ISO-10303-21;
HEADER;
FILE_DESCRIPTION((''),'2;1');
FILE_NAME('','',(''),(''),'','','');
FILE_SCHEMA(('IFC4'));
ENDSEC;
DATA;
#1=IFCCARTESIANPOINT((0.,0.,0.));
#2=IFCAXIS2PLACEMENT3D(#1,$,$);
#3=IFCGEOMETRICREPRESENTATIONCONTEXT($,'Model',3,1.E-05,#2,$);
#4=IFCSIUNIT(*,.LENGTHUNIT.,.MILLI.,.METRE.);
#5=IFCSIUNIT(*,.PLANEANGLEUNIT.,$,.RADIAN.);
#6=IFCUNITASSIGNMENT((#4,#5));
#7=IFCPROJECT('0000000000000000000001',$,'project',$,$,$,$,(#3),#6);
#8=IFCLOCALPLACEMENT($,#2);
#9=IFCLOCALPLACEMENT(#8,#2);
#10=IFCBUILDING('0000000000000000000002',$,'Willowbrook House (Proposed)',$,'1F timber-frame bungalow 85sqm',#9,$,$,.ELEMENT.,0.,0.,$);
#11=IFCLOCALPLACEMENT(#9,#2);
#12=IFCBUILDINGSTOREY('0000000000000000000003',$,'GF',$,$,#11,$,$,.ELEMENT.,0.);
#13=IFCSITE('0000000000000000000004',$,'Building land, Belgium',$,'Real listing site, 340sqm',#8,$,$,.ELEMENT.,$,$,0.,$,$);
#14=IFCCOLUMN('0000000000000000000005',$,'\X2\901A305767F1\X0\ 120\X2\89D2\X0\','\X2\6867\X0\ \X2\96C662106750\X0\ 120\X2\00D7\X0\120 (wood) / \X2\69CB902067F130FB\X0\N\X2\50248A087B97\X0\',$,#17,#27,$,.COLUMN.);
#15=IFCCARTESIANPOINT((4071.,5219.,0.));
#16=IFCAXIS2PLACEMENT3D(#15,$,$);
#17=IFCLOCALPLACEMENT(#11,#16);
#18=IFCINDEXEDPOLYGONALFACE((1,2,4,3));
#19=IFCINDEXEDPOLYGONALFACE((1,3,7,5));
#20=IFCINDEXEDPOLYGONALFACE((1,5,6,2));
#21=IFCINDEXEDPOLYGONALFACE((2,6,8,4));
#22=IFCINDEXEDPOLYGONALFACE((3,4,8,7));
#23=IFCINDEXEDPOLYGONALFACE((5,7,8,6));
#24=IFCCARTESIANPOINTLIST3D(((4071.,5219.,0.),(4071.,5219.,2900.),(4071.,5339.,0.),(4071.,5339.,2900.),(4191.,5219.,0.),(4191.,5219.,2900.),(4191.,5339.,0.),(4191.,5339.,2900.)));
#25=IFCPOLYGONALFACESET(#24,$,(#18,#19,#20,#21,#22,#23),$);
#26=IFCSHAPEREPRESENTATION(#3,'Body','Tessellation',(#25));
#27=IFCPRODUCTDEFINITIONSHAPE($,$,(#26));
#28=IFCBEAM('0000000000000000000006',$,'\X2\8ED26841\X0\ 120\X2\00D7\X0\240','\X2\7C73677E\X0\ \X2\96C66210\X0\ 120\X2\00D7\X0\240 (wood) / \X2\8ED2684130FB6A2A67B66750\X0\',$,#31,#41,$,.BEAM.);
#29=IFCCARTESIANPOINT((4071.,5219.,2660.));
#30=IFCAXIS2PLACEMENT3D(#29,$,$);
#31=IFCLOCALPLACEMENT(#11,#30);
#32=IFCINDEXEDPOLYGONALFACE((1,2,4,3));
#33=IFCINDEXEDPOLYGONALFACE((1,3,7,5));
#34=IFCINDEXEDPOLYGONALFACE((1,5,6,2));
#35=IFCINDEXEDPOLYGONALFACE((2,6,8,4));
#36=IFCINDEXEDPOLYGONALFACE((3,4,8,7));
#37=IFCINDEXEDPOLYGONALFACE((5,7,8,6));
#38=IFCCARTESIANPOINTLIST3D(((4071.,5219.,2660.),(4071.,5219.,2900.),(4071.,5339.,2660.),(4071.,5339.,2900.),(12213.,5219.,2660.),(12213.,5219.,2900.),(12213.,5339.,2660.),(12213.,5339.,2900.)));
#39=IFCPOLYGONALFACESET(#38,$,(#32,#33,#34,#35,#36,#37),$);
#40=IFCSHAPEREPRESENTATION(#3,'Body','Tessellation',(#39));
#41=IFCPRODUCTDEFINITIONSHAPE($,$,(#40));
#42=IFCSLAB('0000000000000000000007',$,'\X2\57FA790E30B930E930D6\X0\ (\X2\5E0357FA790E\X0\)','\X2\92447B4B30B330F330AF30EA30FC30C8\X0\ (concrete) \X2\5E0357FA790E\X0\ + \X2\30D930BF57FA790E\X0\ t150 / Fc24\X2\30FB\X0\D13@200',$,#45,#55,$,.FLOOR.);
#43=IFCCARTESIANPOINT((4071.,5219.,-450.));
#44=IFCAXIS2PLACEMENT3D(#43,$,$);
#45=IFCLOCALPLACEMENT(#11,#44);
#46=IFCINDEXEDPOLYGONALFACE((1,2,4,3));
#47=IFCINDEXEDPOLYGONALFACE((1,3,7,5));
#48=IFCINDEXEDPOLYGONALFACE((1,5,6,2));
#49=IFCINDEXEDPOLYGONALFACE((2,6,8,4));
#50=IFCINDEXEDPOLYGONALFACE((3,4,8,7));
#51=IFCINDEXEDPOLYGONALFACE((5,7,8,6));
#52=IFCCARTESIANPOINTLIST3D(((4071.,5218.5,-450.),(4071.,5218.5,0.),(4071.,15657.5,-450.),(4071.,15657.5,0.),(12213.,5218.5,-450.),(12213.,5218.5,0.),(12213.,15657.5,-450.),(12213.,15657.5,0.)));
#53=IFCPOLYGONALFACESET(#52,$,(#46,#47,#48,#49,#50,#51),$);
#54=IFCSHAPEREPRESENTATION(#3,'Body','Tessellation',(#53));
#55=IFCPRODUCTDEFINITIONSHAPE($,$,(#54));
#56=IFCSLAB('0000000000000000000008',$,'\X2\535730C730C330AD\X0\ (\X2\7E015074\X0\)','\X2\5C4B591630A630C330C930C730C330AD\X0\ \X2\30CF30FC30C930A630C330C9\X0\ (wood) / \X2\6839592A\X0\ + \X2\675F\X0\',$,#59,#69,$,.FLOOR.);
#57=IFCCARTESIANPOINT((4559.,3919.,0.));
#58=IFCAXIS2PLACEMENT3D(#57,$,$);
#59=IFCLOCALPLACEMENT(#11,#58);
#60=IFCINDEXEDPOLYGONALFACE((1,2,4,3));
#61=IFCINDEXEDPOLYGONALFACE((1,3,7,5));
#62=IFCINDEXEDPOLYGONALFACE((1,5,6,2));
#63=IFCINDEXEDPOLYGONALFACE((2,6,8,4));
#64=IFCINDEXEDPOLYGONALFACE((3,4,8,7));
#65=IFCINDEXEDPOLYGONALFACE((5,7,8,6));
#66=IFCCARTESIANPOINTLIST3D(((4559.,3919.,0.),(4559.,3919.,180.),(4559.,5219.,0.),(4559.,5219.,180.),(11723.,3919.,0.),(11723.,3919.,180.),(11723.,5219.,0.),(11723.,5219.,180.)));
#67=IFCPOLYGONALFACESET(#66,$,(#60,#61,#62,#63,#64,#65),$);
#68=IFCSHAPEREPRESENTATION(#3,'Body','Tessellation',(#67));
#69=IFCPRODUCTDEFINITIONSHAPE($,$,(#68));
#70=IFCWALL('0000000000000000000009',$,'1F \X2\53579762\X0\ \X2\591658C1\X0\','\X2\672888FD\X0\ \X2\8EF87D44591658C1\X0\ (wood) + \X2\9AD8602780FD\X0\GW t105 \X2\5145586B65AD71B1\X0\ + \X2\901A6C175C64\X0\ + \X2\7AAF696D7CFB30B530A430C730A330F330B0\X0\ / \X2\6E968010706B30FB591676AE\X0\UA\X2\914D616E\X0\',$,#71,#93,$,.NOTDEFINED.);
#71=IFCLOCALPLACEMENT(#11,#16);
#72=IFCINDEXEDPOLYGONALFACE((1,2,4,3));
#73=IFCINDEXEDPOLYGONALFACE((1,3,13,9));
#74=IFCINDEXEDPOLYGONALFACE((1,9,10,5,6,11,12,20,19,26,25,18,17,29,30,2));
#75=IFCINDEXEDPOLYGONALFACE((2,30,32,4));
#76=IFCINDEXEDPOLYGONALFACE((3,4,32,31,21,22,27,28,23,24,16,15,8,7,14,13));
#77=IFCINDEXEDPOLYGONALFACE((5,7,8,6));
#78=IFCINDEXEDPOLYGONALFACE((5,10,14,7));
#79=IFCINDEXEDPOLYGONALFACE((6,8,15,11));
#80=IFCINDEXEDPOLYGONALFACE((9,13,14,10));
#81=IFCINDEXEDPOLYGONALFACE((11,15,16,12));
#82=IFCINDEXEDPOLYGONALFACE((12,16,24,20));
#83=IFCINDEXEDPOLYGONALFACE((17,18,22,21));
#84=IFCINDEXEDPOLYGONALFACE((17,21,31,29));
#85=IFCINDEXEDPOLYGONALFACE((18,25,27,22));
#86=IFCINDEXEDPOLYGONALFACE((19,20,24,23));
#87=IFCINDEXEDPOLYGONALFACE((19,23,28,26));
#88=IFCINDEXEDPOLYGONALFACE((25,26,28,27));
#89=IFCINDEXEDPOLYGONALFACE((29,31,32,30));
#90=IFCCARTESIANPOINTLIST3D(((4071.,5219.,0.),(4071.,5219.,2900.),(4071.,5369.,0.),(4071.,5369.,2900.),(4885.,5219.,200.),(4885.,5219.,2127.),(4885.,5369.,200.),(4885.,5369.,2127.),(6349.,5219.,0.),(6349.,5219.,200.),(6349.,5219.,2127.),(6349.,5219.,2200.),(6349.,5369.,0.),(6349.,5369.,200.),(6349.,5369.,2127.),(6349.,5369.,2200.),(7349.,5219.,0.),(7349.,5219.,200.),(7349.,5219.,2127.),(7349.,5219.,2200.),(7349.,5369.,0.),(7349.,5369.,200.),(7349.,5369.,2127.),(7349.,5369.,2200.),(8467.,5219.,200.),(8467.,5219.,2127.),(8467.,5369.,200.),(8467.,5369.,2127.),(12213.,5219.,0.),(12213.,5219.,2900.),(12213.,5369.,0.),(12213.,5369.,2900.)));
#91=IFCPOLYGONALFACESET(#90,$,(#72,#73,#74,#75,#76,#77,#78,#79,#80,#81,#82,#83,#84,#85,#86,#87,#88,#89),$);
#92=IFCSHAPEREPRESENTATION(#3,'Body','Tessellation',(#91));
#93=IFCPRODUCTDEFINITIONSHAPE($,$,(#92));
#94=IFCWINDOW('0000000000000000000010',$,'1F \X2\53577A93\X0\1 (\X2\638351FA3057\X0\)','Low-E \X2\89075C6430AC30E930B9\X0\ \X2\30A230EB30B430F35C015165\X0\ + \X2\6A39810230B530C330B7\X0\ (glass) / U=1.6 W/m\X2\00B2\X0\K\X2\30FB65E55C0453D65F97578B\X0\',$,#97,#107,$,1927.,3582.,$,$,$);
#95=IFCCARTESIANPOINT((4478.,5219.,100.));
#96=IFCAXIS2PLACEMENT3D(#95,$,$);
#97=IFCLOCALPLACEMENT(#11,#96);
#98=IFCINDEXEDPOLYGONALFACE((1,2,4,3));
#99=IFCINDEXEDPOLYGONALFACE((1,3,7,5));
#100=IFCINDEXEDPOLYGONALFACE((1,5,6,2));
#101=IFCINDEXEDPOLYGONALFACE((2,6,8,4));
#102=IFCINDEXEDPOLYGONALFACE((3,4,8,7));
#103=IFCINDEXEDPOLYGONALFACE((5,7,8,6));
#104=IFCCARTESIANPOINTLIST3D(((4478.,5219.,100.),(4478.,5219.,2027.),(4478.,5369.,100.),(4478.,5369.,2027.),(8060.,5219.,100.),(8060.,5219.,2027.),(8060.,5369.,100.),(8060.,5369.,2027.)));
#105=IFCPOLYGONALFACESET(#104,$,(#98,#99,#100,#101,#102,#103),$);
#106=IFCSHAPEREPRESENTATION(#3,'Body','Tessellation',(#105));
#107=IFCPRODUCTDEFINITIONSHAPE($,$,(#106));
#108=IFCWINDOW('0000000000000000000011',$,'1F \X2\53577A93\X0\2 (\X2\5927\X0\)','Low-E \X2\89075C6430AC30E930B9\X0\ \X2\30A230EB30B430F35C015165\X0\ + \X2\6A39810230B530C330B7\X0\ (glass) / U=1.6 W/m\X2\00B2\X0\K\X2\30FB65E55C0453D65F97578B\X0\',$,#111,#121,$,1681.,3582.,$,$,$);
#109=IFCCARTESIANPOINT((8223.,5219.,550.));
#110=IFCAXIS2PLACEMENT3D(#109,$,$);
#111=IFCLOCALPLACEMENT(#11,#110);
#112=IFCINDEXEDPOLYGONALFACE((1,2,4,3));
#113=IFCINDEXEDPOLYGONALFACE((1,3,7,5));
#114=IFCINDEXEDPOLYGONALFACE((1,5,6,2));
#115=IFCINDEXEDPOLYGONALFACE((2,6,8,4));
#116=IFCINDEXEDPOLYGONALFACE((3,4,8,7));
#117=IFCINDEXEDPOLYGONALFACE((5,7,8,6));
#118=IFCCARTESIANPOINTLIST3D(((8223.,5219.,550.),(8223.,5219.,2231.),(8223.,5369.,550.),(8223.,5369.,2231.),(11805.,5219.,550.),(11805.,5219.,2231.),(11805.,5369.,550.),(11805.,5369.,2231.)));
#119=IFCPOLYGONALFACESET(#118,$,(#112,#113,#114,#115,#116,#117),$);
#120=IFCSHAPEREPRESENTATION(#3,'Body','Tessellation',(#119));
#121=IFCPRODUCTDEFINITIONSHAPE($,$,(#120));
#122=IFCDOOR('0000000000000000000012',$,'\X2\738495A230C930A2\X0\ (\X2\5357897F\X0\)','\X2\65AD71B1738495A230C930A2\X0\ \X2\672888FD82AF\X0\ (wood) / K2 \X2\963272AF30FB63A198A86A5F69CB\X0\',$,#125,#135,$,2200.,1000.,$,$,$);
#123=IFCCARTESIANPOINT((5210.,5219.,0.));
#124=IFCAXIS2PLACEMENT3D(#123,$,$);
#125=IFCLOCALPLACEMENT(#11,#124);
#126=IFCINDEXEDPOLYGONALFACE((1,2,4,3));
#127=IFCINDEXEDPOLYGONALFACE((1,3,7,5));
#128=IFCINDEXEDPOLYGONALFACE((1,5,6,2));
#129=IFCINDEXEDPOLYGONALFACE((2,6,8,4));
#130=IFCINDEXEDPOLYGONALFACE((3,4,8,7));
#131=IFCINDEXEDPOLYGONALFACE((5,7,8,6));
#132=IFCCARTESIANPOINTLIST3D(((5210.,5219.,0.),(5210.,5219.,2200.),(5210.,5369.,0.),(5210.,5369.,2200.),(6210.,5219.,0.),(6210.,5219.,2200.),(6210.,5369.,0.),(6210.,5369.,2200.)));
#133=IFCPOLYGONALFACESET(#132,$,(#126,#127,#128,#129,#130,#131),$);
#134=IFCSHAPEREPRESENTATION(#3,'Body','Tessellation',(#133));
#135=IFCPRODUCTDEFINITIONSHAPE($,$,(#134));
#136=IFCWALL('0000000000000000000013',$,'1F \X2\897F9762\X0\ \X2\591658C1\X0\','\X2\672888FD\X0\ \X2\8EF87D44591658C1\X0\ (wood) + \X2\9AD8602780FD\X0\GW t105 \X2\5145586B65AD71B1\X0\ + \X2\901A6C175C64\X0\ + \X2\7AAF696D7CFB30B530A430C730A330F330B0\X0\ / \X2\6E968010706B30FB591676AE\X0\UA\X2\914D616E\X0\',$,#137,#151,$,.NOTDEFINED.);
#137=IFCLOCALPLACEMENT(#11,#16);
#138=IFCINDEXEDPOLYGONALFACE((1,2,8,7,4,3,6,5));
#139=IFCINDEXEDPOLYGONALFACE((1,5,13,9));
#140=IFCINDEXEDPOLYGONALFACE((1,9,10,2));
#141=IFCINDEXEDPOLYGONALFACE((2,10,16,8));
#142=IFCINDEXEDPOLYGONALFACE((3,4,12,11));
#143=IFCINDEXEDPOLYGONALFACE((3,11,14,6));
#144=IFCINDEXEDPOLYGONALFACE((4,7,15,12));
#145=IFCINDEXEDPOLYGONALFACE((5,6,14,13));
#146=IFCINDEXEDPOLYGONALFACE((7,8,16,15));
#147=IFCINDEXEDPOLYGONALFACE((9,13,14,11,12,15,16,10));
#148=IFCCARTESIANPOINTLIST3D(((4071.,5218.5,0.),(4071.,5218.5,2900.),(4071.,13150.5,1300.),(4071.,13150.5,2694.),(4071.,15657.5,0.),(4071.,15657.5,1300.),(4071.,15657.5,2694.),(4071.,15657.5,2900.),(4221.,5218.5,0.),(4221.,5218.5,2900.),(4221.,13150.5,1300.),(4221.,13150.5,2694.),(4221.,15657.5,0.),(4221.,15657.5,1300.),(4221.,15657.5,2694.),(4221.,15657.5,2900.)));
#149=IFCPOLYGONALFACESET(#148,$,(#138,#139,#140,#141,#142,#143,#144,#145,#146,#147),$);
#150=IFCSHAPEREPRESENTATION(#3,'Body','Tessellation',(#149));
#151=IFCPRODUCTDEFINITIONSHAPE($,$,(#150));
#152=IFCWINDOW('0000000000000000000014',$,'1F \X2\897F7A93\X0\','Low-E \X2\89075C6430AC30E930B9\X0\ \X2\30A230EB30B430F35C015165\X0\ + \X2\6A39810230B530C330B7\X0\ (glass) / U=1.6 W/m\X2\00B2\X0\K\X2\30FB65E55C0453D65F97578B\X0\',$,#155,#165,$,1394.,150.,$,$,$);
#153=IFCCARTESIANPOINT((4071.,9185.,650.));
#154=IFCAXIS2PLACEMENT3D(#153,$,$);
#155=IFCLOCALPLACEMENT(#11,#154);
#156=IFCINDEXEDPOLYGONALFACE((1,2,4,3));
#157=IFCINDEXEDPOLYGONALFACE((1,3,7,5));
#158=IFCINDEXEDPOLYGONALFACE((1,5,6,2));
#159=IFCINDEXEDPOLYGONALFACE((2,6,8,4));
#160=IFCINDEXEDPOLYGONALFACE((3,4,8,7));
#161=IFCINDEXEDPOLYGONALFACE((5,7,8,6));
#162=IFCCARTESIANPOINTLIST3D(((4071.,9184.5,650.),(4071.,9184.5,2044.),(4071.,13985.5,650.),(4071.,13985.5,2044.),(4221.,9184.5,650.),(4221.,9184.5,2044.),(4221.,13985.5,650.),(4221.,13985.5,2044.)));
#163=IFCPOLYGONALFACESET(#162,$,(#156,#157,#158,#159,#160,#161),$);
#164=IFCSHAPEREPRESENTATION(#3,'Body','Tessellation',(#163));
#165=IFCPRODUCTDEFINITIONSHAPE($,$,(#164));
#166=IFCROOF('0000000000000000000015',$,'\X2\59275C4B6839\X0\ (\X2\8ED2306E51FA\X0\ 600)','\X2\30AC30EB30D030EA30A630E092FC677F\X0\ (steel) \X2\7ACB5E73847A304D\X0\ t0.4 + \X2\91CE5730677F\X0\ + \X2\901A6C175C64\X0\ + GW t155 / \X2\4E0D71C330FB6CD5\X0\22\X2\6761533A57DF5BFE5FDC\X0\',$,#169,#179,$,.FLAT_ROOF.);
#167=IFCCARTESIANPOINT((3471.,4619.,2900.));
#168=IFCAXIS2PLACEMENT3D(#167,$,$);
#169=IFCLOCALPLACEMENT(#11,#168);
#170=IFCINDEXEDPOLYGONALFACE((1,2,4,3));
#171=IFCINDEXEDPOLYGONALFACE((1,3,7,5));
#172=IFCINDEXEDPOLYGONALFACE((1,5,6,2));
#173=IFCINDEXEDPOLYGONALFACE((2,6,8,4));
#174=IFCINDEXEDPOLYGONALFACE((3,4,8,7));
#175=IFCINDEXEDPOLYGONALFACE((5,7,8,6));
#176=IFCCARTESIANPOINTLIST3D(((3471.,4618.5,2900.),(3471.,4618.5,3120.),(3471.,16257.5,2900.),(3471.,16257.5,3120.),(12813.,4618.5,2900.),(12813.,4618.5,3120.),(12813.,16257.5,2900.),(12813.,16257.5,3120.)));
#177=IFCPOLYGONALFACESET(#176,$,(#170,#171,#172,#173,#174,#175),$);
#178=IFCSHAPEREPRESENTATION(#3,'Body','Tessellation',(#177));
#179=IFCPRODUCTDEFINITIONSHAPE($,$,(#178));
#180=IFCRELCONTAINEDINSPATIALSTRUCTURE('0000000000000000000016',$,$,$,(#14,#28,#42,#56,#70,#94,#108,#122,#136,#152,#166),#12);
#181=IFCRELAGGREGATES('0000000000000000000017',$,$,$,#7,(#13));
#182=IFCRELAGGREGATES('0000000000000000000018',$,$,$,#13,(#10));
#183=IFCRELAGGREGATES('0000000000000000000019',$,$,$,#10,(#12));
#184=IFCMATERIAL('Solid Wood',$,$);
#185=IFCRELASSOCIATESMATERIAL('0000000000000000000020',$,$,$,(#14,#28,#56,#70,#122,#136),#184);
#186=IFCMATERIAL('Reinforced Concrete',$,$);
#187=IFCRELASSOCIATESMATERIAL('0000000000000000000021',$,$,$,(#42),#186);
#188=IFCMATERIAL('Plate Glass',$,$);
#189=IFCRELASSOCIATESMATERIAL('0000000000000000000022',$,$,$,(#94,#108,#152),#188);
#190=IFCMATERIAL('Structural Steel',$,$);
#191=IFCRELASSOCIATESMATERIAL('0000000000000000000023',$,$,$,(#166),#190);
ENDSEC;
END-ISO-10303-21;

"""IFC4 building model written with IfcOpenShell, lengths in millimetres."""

from ifc_helpers import new_model, si_unit, frame, frame_2d, origin, place, context, project, spatial, rectangle, extrude, material, element, fill, save


model = new_model("IFC4")

# Units and contexts
model_context = context("Model", 3, precision=1e-05, world=origin())
ifc_project = project(units=[si_unit("LENGTHUNIT", "METRE", prefix="MILLI"), si_unit("PLANEANGLEUNIT", "RADIAN")], contexts=[model_context])

# Site, building, storey
site_placement = place(None, origin())
site = spatial("IfcSite", under=ifc_project, at=site_placement, Name="Building land, Belgium", ObjectType="Real listing site, 340sqm", CompositionType="ELEMENT", RefElevation=0.0)
building_placement = place(site_placement, origin())
building = spatial("IfcBuilding", under=site, at=building_placement, Name="Willowbrook House (Proposed)", ObjectType="1F timber-frame bungalow 85sqm", CompositionType="ELEMENT", ElevationOfRefHeight=0.0, ElevationOfTerrain=0.0)
storey_placement = place(building_placement, origin())
storey = spatial("IfcBuildingStorey", under=building, at=storey_placement, Name="GF", CompositionType="ELEMENT", Elevation=0.0)

# Column
ifc_material_1 = material(Name="Solid Wood")
column_1_placement = place(storey_placement, frame((4071.0, 5219.0, 0.0)))
element("IfcColumn", 1, at=column_1_placement, inside=storey, material=ifc_material_1, Name="通し柱 120角", Description="桧 集成材 120×120 (wood) / 構造柱・N値計算", PredefinedType="COLUMN", context=model_context, shape_type="SweptSolid", body=[
    extrude(rectangle(XDim=120.0, YDim=120.0, at=frame_2d((60.0, 60.0))), frame((4071.0, 5219.0, 0.0)), (0.0, 0.0, 1.0), 2900.0),
])

# Beam
beam_1_placement = place(storey_placement, frame((4071.0, 5219.0, 2660.0)))
element("IfcBeam", 2, at=beam_1_placement, inside=storey, material=ifc_material_1, Name="軒桁 120×240", Description="米松 集成 120×240 (wood) / 軒桁・横架材", PredefinedType="BEAM", context=model_context, shape_type="SweptSolid", body=[
    extrude(rectangle(XDim=8142.0, YDim=120.0, at=frame_2d((4071.0, 60.0))), frame((4071.0, 5219.0, 2660.0)), (0.0, 0.0, 1.0), 240.0),
])

# Slabs
ifc_material_2 = material(Name="Reinforced Concrete")
slab_1_placement = place(storey_placement, frame((4071.0, 5219.0, -450.0)))
element("IfcSlab", 3, at=slab_1_placement, inside=storey, material=ifc_material_2, Name="基礎スラブ (布基礎)", Description="鉄筋コンクリート (concrete) 布基礎 + ベタ基礎 t150 / Fc24・D13@200", PredefinedType="FLOOR", context=model_context, shape_type="SweptSolid", body=[
    extrude(rectangle(XDim=8142.0, YDim=10439.0, at=frame_2d((4071.0, 5219.0))), frame((4071.0, 5219.0, -450.0)), (0.0, 0.0, 1.0), 450.0),
])
slab_2_placement = place(storey_placement, frame((4559.0, 3919.0, 0.0)))
element("IfcSlab", 4, at=slab_2_placement, inside=storey, material=ifc_material_1, Name="南デッキ (縁側)", Description="屋外ウッドデッキ ハードウッド (wood) / 根太 + 束", PredefinedType="FLOOR", context=model_context, shape_type="SweptSolid", body=[
    extrude(rectangle(XDim=7164.0, YDim=1300.0, at=frame_2d((3582.0, 650.0))), frame((4559.0, 3919.0, 0.0)), (0.0, 0.0, 1.0), 180.0),
])

# Wall, openings, windows, door
wall_1_placement = place(storey_placement, frame((4071.0, 5219.0, 0.0)))
wall_1 = element("IfcWall", 5, at=wall_1_placement, inside=storey, material=ifc_material_1, Name="1F 南面 外壁", Description="木製 軸組外壁 (wood) + 高性能GW t105 充填断熱 + 通気層 + 窯業系サイディング / 準耐火・外皮UA配慮", PredefinedType="NOTDEFINED", context=model_context, shape_type="SweptSolid", body=[
    extrude(rectangle(XDim=8142.0, YDim=150.0, at=frame_2d((4071.0, 75.0))), frame((4071.0, 5219.0, 0.0)), (0.0, 0.0, 1.0), 2900.0),
])
opening_1_placement = place(storey_placement, frame((4478.0, 5219.0, 100.0)))
opening_1 = element("IfcOpeningElement", 6, at=opening_1_placement, cuts=wall_1, PredefinedType="NOTDEFINED", context=model_context, shape_type="SweptSolid", body=[
    extrude(rectangle(XDim=3582.0, YDim=150.0, at=frame_2d((1791.0, 75.0))), frame((4478.0, 5219.0, 100.0)), (0.0, 0.0, 1.0), 1927.0),
])
opening_2_placement = place(storey_placement, frame((8223.0, 5219.0, 550.0)))
opening_2 = element("IfcOpeningElement", 7, at=opening_2_placement, cuts=wall_1, PredefinedType="NOTDEFINED", context=model_context, shape_type="SweptSolid", body=[
    extrude(rectangle(XDim=3582.0, YDim=150.0, at=frame_2d((1791.0, 75.0))), frame((8223.0, 5219.0, 550.0)), (0.0, 0.0, 1.0), 1681.0),
])
opening_3_placement = place(storey_placement, frame((5210.0, 5219.0, 0.0)))
opening_3 = element("IfcOpeningElement", 8, at=opening_3_placement, cuts=wall_1, PredefinedType="NOTDEFINED", context=model_context, shape_type="SweptSolid", body=[
    extrude(rectangle(XDim=1000.0, YDim=150.0, at=frame_2d((500.0, 75.0))), frame((5210.0, 5219.0, 0.0)), (0.0, 0.0, 1.0), 2200.0),
])
ifc_material_3 = material(Name="Plate Glass")
window_1_placement = place(storey_placement, frame((4478.0, 5219.0, 100.0)))
window_1 = element("IfcWindow", 9, at=window_1_placement, inside=storey, material=ifc_material_3, Name="1F 南窓1 (掃出し)", Description="Low-E 複層ガラス アルゴン封入 + 樹脂サッシ (glass) / U=1.6 W/m²K・日射取得型", OverallHeight=1927.0, OverallWidth=3582.0, context=model_context, shape_type="SweptSolid", body=[
    extrude(rectangle(XDim=3582.0, YDim=150.0, at=frame_2d((1791.0, 75.0))), frame((4478.0, 5219.0, 100.0)), (0.0, 0.0, 1.0), 1927.0),
])
fill(opening_1, window_1)
window_2_placement = place(storey_placement, frame((8223.0, 5219.0, 550.0)))
window_2 = element("IfcWindow", 10, at=window_2_placement, inside=storey, material=ifc_material_3, Name="1F 南窓2 (大)", Description="Low-E 複層ガラス アルゴン封入 + 樹脂サッシ (glass) / U=1.6 W/m²K・日射取得型", OverallHeight=1681.0, OverallWidth=3582.0, context=model_context, shape_type="SweptSolid", body=[
    extrude(rectangle(XDim=3582.0, YDim=150.0, at=frame_2d((1791.0, 75.0))), frame((8223.0, 5219.0, 550.0)), (0.0, 0.0, 1.0), 1681.0),
])
fill(opening_2, window_2)
door_placement = place(storey_placement, frame((5210.0, 5219.0, 0.0)))
door = element("IfcDoor", 11, at=door_placement, inside=storey, material=ifc_material_1, Name="玄関ドア (南西)", Description="断熱玄関ドア 木製芯 (wood) / K2 防犯・採風機構", OverallHeight=2200.0, OverallWidth=1000.0, context=model_context, shape_type="SweptSolid", body=[
    extrude(rectangle(XDim=1000.0, YDim=150.0, at=frame_2d((500.0, 75.0))), frame((5210.0, 5219.0, 0.0)), (0.0, 0.0, 1.0), 2200.0),
])
fill(opening_3, door)

# Wall, opening, window
wall_2_placement = place(storey_placement, frame((4071.0, 5219.0, 0.0)))
wall_2 = element("IfcWall", 12, at=wall_2_placement, inside=storey, material=ifc_material_1, Name="1F 西面 外壁", Description="木製 軸組外壁 (wood) + 高性能GW t105 充填断熱 + 通気層 + 窯業系サイディング / 準耐火・外皮UA配慮", PredefinedType="NOTDEFINED", context=model_context, shape_type="SweptSolid", body=[
    extrude(rectangle(XDim=150.0, YDim=10439.0, at=frame_2d((75.0, 5219.0))), frame((4071.0, 5219.0, 0.0)), (0.0, 0.0, 1.0), 2900.0),
])
opening_4_placement = place(storey_placement, frame((4071.0, 9185.0, 650.0)))
opening_4 = element("IfcOpeningElement", 13, at=opening_4_placement, cuts=wall_2, PredefinedType="NOTDEFINED", context=model_context, shape_type="SweptSolid", body=[
    extrude(rectangle(XDim=150.0, YDim=4801.0, at=frame_2d((75.0, 2400.0))), frame((4071.0, 9185.0, 650.0)), (0.0, 0.0, 1.0), 1394.0),
])
window_3_placement = place(storey_placement, frame((4071.0, 9185.0, 650.0)))
window_3 = element("IfcWindow", 14, at=window_3_placement, inside=storey, material=ifc_material_3, Name="1F 西窓", Description="Low-E 複層ガラス アルゴン封入 + 樹脂サッシ (glass) / U=1.6 W/m²K・日射取得型", OverallHeight=1394.0, OverallWidth=150.0, context=model_context, shape_type="SweptSolid", body=[
    extrude(rectangle(XDim=150.0, YDim=4801.0, at=frame_2d((75.0, 2400.0))), frame((4071.0, 9185.0, 650.0)), (0.0, 0.0, 1.0), 1394.0),
])
fill(opening_4, window_3)

# Roof
ifc_material_4 = material(Name="Structural Steel")
roof_placement = place(storey_placement, frame((3471.0, 4619.0, 2900.0)))
element("IfcRoof", 15, at=roof_placement, inside=storey, material=ifc_material_4, Name="大屋根 (軒の出 600)", Description="ガルバリウム鋼板 (steel) 立平葺き t0.4 + 野地板 + 通気層 + GW t155 / 不燃・法22条区域対応", PredefinedType="FLAT_ROOF", context=model_context, shape_type="SweptSolid", body=[
    extrude(rectangle(XDim=9342.0, YDim=11639.0, at=frame_2d((4671.0, 5819.0))), frame((3471.0, 4619.0, 2900.0)), (0.0, 0.0, 1.0), 220.0),
])

save(model, "model.ifc")
